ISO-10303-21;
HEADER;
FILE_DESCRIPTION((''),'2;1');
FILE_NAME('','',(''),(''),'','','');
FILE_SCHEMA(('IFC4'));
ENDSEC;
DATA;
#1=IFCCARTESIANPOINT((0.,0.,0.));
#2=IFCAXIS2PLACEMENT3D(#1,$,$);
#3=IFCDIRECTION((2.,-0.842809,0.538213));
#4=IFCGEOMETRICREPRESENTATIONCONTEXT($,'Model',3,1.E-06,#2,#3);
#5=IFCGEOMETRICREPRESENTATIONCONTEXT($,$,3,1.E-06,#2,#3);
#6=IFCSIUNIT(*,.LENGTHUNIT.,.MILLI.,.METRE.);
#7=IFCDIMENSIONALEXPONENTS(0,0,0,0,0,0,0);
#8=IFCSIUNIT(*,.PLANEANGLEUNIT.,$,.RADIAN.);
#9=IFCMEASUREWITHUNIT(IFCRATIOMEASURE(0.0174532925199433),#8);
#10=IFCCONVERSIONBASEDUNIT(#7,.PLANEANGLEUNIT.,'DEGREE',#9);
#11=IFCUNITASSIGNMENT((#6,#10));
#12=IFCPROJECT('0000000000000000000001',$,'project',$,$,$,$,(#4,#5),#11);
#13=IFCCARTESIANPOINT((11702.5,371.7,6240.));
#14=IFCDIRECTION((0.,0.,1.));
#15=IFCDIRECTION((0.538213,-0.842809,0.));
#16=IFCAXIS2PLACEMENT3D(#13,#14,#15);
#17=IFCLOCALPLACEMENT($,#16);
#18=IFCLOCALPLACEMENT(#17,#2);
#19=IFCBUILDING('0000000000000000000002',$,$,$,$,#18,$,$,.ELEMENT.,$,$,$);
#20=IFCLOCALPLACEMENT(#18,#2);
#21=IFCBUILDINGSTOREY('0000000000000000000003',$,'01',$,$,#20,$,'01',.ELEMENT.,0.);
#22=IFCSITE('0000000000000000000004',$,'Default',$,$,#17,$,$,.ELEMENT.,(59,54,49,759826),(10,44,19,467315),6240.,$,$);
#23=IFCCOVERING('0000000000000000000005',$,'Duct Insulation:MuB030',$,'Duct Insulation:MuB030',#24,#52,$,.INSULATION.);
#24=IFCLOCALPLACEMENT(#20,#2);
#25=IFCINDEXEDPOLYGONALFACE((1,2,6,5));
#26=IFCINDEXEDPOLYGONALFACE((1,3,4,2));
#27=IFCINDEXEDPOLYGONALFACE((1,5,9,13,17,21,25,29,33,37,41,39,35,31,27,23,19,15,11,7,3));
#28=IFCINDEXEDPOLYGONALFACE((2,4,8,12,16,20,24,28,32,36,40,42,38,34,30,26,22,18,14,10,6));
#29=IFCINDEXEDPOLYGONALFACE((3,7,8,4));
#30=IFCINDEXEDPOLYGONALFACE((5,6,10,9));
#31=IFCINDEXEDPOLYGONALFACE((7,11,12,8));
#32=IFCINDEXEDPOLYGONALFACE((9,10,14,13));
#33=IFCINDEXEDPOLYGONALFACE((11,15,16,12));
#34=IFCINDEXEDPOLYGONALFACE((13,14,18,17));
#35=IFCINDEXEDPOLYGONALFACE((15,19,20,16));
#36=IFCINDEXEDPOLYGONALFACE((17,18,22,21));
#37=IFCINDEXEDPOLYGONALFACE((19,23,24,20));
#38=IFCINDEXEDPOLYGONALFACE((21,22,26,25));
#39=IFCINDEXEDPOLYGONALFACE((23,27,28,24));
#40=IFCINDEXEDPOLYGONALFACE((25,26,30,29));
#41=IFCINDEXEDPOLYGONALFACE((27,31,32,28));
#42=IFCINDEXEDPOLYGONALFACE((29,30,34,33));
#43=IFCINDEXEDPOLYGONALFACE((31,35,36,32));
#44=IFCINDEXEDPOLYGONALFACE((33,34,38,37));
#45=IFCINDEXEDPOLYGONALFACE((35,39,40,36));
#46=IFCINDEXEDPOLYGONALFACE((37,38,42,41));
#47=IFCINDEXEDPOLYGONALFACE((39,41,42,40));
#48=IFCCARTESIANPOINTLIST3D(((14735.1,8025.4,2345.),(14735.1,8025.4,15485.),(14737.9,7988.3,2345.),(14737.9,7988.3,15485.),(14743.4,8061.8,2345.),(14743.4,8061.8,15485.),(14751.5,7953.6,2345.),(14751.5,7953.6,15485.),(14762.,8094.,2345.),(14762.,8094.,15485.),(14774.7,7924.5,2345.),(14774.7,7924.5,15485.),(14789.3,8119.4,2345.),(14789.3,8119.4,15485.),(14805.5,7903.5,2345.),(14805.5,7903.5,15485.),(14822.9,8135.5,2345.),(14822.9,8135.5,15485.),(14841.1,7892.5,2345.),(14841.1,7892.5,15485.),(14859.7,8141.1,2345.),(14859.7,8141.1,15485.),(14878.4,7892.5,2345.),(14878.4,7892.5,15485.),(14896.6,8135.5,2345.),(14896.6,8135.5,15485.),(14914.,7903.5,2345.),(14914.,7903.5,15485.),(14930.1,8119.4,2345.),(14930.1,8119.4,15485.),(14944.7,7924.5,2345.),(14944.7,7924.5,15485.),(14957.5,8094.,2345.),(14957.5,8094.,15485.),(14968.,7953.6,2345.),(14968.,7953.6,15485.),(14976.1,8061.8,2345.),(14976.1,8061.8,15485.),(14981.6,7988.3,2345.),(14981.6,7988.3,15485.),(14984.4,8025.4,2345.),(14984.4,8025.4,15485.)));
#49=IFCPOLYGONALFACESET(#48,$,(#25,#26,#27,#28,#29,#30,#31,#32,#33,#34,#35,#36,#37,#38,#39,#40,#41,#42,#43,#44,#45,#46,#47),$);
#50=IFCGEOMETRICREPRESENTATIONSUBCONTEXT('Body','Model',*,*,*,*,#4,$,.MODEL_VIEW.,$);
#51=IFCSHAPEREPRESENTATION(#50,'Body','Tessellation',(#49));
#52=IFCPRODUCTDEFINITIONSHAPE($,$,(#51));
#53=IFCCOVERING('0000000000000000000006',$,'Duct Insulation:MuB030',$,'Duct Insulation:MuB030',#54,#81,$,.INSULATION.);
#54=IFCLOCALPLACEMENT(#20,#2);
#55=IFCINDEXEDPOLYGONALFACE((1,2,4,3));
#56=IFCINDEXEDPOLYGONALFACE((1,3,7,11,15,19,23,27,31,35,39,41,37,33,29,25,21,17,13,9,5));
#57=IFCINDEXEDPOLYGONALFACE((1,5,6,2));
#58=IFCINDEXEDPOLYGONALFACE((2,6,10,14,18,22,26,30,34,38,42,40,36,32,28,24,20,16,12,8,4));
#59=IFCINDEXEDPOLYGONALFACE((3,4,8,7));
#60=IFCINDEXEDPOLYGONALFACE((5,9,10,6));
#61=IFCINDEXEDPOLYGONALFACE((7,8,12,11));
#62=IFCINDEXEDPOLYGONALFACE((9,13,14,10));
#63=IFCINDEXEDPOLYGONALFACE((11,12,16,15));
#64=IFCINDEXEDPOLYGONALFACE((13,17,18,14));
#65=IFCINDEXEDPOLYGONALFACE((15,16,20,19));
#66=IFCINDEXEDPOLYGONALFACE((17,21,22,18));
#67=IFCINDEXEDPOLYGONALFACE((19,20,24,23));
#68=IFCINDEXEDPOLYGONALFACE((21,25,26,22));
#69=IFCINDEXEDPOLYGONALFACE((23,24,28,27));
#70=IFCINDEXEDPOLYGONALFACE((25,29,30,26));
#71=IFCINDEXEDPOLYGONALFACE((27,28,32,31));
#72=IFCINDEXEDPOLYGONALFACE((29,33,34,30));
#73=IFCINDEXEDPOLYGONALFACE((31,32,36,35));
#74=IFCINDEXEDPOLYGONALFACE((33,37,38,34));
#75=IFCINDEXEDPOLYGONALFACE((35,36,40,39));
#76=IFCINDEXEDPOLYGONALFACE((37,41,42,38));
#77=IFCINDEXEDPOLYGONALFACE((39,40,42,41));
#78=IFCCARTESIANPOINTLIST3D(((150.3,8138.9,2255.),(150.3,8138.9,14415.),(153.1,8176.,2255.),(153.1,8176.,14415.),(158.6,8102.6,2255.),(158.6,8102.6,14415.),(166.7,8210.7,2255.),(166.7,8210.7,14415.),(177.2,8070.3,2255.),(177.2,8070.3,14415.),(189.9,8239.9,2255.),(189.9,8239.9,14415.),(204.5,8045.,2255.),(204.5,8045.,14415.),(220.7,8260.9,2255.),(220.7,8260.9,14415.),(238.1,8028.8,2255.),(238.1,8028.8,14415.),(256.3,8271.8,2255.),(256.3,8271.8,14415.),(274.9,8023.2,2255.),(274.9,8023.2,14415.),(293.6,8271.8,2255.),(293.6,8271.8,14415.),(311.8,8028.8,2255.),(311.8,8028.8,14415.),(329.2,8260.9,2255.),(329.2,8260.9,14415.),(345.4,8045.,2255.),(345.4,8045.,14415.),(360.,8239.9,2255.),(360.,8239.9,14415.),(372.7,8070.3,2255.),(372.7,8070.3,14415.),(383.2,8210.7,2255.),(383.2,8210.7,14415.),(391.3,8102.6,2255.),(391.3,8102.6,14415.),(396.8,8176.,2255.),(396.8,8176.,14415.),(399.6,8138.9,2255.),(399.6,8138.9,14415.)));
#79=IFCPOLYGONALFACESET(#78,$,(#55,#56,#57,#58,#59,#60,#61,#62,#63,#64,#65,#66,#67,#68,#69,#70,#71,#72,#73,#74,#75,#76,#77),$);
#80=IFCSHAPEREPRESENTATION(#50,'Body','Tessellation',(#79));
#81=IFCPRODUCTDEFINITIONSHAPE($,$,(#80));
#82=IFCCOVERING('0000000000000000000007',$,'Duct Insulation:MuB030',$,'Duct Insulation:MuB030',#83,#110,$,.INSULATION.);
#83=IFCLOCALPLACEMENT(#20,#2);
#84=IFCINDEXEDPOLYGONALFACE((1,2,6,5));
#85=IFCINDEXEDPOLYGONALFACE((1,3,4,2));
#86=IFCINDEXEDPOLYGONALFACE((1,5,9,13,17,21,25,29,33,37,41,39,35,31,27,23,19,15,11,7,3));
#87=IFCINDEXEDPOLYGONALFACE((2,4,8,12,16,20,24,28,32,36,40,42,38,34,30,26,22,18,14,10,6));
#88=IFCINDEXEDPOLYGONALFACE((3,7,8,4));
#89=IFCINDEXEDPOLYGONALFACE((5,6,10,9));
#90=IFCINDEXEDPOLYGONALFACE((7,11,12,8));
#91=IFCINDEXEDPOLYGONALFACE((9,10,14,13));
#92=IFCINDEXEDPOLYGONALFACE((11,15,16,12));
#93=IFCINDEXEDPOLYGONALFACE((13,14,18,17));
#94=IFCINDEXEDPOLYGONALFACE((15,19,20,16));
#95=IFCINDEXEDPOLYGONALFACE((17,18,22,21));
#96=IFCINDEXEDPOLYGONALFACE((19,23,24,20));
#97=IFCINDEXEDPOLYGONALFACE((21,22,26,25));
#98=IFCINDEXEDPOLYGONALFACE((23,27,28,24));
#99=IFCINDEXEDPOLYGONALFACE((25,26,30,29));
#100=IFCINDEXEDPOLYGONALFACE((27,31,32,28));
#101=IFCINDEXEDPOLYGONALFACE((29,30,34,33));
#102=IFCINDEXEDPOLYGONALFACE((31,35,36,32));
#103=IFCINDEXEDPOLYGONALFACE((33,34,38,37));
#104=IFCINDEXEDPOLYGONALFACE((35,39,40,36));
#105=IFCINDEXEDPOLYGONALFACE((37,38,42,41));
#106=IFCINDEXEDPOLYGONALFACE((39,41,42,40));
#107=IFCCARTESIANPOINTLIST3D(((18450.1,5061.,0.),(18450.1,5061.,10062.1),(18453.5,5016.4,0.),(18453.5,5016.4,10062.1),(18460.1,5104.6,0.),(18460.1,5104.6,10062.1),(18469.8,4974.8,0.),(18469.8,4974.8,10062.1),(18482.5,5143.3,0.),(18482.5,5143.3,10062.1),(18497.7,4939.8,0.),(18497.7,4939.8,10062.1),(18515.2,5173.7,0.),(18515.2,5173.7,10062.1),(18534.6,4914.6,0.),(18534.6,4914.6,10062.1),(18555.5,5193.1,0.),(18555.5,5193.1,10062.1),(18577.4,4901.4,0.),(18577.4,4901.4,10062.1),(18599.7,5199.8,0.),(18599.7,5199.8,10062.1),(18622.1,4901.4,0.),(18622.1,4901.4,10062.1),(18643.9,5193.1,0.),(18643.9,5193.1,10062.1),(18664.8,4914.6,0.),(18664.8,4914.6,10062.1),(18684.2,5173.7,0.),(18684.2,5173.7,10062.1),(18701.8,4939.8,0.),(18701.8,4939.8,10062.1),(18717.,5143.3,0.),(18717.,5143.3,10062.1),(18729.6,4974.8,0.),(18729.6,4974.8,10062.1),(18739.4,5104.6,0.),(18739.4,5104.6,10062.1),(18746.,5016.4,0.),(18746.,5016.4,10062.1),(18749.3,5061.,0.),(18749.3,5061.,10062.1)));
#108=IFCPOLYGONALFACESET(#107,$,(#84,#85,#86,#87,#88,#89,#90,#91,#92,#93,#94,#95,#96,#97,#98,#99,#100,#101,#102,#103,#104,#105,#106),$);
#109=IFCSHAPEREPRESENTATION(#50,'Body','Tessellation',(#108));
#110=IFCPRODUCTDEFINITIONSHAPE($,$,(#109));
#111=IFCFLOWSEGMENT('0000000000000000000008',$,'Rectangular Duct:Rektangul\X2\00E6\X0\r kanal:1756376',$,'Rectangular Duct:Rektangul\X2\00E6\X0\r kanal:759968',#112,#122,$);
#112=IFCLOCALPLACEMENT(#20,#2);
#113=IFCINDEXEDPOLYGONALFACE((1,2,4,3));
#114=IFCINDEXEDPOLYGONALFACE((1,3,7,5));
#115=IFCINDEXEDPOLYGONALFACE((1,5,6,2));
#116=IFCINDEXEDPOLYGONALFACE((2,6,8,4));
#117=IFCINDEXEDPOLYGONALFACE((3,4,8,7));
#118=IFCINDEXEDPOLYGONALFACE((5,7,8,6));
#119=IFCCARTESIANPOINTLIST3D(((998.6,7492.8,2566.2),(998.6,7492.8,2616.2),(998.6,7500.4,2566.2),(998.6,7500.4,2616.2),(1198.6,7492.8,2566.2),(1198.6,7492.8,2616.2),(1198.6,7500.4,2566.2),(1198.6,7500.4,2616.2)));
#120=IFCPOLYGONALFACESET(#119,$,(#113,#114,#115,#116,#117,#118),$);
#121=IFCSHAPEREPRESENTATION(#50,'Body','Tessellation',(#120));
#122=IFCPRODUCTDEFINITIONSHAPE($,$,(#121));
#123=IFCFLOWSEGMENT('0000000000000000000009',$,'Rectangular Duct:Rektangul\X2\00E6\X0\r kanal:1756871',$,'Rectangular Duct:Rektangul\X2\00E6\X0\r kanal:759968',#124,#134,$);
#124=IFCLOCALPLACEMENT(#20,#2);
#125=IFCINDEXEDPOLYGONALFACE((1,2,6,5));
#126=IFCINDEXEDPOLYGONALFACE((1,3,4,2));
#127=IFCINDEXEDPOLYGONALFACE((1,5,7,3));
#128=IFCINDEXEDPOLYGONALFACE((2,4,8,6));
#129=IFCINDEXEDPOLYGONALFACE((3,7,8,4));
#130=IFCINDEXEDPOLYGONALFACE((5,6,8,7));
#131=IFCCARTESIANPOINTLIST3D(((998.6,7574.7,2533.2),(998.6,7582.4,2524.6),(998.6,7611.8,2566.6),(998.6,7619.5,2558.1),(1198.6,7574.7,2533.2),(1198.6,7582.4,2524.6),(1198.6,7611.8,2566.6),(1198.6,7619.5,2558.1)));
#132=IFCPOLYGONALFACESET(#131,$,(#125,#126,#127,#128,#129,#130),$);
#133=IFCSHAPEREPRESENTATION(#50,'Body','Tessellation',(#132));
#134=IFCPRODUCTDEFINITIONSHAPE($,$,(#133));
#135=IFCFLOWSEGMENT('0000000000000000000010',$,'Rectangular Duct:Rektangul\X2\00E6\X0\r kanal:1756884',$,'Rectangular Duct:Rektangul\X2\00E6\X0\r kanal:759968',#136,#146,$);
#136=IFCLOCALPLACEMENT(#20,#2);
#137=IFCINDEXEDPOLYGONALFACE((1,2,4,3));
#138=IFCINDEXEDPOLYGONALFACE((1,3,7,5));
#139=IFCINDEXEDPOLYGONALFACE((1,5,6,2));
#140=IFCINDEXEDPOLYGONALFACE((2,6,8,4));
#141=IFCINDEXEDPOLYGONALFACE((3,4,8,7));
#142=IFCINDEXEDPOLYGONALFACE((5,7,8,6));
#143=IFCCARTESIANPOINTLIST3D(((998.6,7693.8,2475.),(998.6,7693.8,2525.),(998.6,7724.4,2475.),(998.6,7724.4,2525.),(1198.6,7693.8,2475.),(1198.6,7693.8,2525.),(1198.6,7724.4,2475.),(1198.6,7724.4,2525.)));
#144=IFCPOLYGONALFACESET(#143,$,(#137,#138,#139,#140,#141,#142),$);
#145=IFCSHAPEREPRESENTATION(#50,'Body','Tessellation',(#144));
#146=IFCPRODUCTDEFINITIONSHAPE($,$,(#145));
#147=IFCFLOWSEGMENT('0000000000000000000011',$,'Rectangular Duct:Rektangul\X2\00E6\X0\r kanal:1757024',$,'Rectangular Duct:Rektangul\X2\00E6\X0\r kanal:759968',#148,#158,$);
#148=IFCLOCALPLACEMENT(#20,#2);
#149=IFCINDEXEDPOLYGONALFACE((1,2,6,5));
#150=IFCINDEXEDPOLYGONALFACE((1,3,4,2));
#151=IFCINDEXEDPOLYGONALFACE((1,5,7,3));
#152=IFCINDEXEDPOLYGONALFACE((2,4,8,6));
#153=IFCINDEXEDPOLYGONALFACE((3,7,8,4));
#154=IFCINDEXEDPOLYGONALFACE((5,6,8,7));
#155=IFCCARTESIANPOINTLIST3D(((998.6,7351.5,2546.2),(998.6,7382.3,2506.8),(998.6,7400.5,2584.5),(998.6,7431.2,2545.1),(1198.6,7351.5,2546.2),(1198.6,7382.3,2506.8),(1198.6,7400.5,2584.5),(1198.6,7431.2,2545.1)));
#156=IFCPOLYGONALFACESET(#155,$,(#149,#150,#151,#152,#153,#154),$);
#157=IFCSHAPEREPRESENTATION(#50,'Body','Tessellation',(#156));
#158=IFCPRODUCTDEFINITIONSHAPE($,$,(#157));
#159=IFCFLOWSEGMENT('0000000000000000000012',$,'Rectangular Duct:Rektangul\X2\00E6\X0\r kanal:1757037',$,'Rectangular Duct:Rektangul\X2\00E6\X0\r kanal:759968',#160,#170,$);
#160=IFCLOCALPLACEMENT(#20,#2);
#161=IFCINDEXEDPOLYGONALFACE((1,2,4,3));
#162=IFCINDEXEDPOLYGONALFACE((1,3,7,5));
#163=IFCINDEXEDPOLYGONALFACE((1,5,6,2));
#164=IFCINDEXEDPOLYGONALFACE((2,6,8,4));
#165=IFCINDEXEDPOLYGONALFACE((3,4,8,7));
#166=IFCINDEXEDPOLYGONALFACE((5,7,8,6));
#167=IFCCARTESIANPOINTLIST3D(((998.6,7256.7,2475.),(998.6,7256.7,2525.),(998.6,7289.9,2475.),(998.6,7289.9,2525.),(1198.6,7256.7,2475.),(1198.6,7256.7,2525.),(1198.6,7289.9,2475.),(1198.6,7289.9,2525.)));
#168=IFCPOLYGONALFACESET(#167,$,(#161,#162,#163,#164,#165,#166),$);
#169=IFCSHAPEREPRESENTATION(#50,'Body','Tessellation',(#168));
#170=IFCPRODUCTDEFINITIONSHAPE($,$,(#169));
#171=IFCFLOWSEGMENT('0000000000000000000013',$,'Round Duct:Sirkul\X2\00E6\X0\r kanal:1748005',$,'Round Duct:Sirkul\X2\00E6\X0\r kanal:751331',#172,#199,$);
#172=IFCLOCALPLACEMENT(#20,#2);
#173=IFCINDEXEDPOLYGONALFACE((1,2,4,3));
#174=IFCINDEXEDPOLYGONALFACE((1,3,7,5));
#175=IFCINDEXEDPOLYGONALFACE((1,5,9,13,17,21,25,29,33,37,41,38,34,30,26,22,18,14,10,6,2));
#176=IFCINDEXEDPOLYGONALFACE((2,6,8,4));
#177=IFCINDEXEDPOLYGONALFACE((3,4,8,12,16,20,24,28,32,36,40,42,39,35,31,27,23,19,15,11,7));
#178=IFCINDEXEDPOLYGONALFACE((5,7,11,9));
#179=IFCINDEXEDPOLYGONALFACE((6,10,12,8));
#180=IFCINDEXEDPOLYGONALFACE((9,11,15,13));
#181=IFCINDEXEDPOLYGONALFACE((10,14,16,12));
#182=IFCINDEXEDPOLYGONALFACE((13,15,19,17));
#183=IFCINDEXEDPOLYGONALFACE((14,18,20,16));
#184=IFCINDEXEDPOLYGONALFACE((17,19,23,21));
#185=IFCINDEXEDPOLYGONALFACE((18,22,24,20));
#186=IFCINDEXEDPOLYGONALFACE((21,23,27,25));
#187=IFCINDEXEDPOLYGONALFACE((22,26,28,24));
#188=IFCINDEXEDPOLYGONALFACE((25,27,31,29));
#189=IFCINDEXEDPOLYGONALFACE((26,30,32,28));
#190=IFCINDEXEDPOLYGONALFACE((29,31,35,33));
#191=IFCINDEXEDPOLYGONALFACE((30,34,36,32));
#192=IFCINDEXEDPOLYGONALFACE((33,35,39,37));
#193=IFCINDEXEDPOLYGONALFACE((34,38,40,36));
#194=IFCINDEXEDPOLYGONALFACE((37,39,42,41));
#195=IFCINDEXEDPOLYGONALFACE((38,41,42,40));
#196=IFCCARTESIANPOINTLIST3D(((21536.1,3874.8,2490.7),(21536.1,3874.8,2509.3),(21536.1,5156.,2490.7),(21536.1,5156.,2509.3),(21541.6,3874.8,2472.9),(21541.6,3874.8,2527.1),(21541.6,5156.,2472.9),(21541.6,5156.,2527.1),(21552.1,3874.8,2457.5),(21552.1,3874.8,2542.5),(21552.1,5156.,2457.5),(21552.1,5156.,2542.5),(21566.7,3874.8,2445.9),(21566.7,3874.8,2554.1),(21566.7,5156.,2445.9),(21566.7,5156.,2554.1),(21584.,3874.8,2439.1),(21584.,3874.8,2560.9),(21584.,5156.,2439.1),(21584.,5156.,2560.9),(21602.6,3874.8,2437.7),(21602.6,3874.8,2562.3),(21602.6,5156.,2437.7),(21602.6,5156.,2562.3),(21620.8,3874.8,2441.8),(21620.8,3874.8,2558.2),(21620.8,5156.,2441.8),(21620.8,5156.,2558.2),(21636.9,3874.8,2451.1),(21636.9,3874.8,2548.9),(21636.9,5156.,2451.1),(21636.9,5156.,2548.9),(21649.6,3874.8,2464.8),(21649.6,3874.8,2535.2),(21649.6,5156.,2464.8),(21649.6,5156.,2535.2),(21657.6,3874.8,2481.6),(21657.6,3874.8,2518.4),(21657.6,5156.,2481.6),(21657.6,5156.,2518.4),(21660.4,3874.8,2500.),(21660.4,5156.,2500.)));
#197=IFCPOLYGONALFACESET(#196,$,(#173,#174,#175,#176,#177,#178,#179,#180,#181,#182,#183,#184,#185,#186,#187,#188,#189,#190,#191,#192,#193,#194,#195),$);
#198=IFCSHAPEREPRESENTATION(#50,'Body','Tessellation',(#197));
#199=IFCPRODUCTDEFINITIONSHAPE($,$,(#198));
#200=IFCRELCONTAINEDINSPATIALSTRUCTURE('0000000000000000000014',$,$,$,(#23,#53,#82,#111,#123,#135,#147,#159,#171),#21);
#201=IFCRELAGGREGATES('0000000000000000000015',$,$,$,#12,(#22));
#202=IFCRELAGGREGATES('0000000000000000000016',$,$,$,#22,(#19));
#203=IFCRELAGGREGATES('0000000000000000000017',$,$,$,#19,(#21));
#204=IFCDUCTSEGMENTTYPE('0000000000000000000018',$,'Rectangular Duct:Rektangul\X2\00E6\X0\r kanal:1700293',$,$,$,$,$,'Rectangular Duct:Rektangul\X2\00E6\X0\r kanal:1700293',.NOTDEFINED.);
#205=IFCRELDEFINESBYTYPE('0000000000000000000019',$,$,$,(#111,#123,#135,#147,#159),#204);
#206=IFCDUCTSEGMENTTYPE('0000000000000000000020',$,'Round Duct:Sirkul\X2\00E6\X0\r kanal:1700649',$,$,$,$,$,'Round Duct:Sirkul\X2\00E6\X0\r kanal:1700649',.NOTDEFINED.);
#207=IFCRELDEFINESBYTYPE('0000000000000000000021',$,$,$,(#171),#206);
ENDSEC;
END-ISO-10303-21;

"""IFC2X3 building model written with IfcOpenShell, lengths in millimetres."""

from ifc_helpers import new_model, entity, si_unit, converted_unit, direction, frame, frame_2d, origin, origin_2d_with_axis, place, context, subcontext, project, spatial, rectangle, circle, extrude, type_object, element, save


model = new_model("IFC2X3")

# Units and contexts
model_context = context("Model", 3, precision=1e-06, world=origin(), true_north=direction((2.0, -0.842809, 0.538213)))
context_of_model = context(None, 3, precision=1e-06, world=origin(), true_north=direction((2.0, -0.842809, 0.538213)))
body_context = subcontext(model_context, "Body", "Model", "MODEL_VIEW")
ifc_project = project(units=[si_unit("LENGTHUNIT", "METRE", prefix="MILLI"), converted_unit("PLANEANGLEUNIT", "DEGREE", entity("IfcRatioMeasure", 0.0174532925199433), si_unit("PLANEANGLEUNIT", "RADIAN"), dimensions=[0, 0, 0, 0, 0, 0, 0])], contexts=[model_context, context_of_model])

# Site, building, storey
site_placement = place(None, frame((11702.5, 371.7, 6240.0), z_axis=(0.0, 0.0, 1.0), x_axis=(0.538213, -0.842809, 0.0)))
site = spatial("IfcSite", under=ifc_project, at=site_placement, Name="Default", CompositionType="ELEMENT", RefLatitude=(59, 54, 49, 759826), RefLongitude=(10, 44, 19, 467315), RefElevation=6240.0)
building_placement = place(site_placement, origin())
building = spatial("IfcBuilding", under=site, at=building_placement, CompositionType="ELEMENT")
storey_placement = place(building_placement, origin())
storey = spatial("IfcBuildingStorey", under=building, at=storey_placement, Name="01", LongName="01", CompositionType="ELEMENT", Elevation=0.0)

# Coverings
covering_1_placement = place(storey_placement, origin())
element("IfcCovering", 1, at=covering_1_placement, inside=storey, Name="Duct Insulation:MuB030", ObjectType="Duct Insulation:MuB030", PredefinedType="INSULATION", context=body_context, shape_type="SweptSolid", body=[
    extrude(circle(Radius=125.0, at=frame_2d((0.0, 0.0), x_axis=(1.0, 0.0))), frame((14859.7, 8016.1, 2345.0), z_axis=(0.0, 0.0, 1.0), x_axis=(0.0, 1.0, 0.0)), (0.0, 0.0, 1.0), 13140.0),
])
covering_2_placement = place(storey_placement, origin())
element("IfcCovering", 2, at=covering_2_placement, inside=storey, Name="Duct Insulation:MuB030", ObjectType="Duct Insulation:MuB030", PredefinedType="INSULATION", context=body_context, shape_type="SweptSolid", body=[
    extrude(circle(Radius=125.0, at=frame_2d((0.0, 0.0), x_axis=(1.0, 0.0))), frame((274.9, 8148.2, 2255.0), z_axis=(0.0, 0.0, 1.0), x_axis=(0.0, -1.0, 0.0)), (0.0, 0.0, 1.0), 12160.0),
])
covering_3_placement = place(storey_placement, origin())
element("IfcCovering", 3, at=covering_3_placement, inside=storey, Name="Duct Insulation:MuB030", ObjectType="Duct Insulation:MuB030", PredefinedType="INSULATION", context=body_context, shape_type="SweptSolid", body=[
    extrude(circle(Radius=150.0, at=frame_2d((0.0, 0.0), x_axis=(1.0, 0.0))), frame((18599.7, 5049.8, 0.0), z_axis=(0.0, 0.0, 1.0), x_axis=(0.0, 1.0, 0.0)), (0.0, 0.0, 1.0), 10062.1),
])

# Flow segments
duct_segment_type_1 = type_object("IfcDuctSegmentType", Name="Rectangular Duct:Rektangulær kanal:1700293", ElementType="Rectangular Duct:Rektangulær kanal:1700293", PredefinedType="NOTDEFINED")
flow_segment_1_placement = place(storey_placement, origin())
element("IfcFlowSegment", 4, at=flow_segment_1_placement, inside=storey, type_object=duct_segment_type_1, Name="Rectangular Duct:Rektangulær kanal:1756376", ObjectType="Rectangular Duct:Rektangulær kanal:759968", context=body_context, shape_type="SweptSolid", body=[
    extrude(rectangle(XDim=7.6, YDim=200.0, at=frame_2d((0.0, 0.0), x_axis=(1.0, 0.0))), frame((1098.6, 7496.6, 2566.2), z_axis=(0.0, 0.0, 1.0), x_axis=(0.0, -1.0, 0.0)), (0.0, 0.0, 1.0), 50.0),
])
flow_segment_2_placement = place(storey_placement, origin())
element("IfcFlowSegment", 5, at=flow_segment_2_placement, inside=storey, type_object=duct_segment_type_1, Name="Rectangular Duct:Rektangulær kanal:1756871", ObjectType="Rectangular Duct:Rektangulær kanal:759968", context=body_context, shape_type="SweptSolid", body=[
    extrude(rectangle(XDim=11.5, YDim=50.0, at=frame_2d((0.0, 0.0), x_axis=(1.0, 0.0))), frame((998.6, 7597.1, 2545.6), z_axis=(1.0, 0.0, 0.0), x_axis=(0.0, 0.669131, -0.743145)), (0.0, 0.0, 1.0), 200.0),
])
flow_segment_3_placement = place(storey_placement, origin())
element("IfcFlowSegment", 6, at=flow_segment_3_placement, inside=storey, type_object=duct_segment_type_1, Name="Rectangular Duct:Rektangulær kanal:1756884", ObjectType="Rectangular Duct:Rektangulær kanal:759968", context=body_context, shape_type="SweptSolid", body=[
    extrude(rectangle(XDim=30.6, YDim=200.0, at=frame_2d((0.0, 0.0), x_axis=(1.0, 0.0))), frame((1098.6, 7709.1, 2475.0), z_axis=(0.0, 0.0, 1.0), x_axis=(0.0, 1.0, 0.0)), (0.0, 0.0, 1.0), 50.0),
])
flow_segment_4_placement = place(storey_placement, origin())
element("IfcFlowSegment", 7, at=flow_segment_4_placement, inside=storey, type_object=duct_segment_type_1, Name="Rectangular Duct:Rektangulær kanal:1757024", ObjectType="Rectangular Duct:Rektangulær kanal:759968", context=body_context, shape_type="SweptSolid", body=[
    extrude(rectangle(XDim=50.0, YDim=62.1, at=frame_2d((0.0, 0.0), x_axis=(0.0, 1.0))), frame((998.6, 7391.4, 2545.6), z_axis=(1.0, 0.0, 0.0), x_axis=(0.0, -0.788011, -0.615661)), (0.0, 0.0, 1.0), 200.0),
])
flow_segment_5_placement = place(storey_placement, origin())
element("IfcFlowSegment", 8, at=flow_segment_5_placement, inside=storey, type_object=duct_segment_type_1, Name="Rectangular Duct:Rektangulær kanal:1757037", ObjectType="Rectangular Duct:Rektangulær kanal:759968", context=body_context, shape_type="SweptSolid", body=[
    extrude(rectangle(XDim=33.2, YDim=200.0, at=frame_2d((0.0, 0.0), x_axis=(1.0, 0.0))), frame((1098.6, 7273.3, 2475.0), z_axis=(0.0, 0.0, 1.0), x_axis=(0.0, -1.0, 0.0)), (0.0, 0.0, 1.0), 50.0),
])
duct_segment_type_2 = type_object("IfcDuctSegmentType", Name="Round Duct:Sirkulær kanal:1700649", ElementType="Round Duct:Sirkulær kanal:1700649", PredefinedType="NOTDEFINED")
flow_segment_6_placement = place(storey_placement, origin())
element("IfcFlowSegment", 9, at=flow_segment_6_placement, inside=storey, type_object=duct_segment_type_2, Name="Round Duct:Sirkulær kanal:1748005", ObjectType="Round Duct:Sirkulær kanal:751331", context=body_context, shape_type="SweptSolid", body=[
    extrude(circle(Radius=62.5, at=origin_2d_with_axis()), frame((21597.9, 3874.8, 2500.0), z_axis=(0.0, 1.0, 0.0), x_axis=(1.0, 0.0, 0.0)), (0.0, 0.0, 1.0), 1281.3),
])

save(model, "model.ifc")
